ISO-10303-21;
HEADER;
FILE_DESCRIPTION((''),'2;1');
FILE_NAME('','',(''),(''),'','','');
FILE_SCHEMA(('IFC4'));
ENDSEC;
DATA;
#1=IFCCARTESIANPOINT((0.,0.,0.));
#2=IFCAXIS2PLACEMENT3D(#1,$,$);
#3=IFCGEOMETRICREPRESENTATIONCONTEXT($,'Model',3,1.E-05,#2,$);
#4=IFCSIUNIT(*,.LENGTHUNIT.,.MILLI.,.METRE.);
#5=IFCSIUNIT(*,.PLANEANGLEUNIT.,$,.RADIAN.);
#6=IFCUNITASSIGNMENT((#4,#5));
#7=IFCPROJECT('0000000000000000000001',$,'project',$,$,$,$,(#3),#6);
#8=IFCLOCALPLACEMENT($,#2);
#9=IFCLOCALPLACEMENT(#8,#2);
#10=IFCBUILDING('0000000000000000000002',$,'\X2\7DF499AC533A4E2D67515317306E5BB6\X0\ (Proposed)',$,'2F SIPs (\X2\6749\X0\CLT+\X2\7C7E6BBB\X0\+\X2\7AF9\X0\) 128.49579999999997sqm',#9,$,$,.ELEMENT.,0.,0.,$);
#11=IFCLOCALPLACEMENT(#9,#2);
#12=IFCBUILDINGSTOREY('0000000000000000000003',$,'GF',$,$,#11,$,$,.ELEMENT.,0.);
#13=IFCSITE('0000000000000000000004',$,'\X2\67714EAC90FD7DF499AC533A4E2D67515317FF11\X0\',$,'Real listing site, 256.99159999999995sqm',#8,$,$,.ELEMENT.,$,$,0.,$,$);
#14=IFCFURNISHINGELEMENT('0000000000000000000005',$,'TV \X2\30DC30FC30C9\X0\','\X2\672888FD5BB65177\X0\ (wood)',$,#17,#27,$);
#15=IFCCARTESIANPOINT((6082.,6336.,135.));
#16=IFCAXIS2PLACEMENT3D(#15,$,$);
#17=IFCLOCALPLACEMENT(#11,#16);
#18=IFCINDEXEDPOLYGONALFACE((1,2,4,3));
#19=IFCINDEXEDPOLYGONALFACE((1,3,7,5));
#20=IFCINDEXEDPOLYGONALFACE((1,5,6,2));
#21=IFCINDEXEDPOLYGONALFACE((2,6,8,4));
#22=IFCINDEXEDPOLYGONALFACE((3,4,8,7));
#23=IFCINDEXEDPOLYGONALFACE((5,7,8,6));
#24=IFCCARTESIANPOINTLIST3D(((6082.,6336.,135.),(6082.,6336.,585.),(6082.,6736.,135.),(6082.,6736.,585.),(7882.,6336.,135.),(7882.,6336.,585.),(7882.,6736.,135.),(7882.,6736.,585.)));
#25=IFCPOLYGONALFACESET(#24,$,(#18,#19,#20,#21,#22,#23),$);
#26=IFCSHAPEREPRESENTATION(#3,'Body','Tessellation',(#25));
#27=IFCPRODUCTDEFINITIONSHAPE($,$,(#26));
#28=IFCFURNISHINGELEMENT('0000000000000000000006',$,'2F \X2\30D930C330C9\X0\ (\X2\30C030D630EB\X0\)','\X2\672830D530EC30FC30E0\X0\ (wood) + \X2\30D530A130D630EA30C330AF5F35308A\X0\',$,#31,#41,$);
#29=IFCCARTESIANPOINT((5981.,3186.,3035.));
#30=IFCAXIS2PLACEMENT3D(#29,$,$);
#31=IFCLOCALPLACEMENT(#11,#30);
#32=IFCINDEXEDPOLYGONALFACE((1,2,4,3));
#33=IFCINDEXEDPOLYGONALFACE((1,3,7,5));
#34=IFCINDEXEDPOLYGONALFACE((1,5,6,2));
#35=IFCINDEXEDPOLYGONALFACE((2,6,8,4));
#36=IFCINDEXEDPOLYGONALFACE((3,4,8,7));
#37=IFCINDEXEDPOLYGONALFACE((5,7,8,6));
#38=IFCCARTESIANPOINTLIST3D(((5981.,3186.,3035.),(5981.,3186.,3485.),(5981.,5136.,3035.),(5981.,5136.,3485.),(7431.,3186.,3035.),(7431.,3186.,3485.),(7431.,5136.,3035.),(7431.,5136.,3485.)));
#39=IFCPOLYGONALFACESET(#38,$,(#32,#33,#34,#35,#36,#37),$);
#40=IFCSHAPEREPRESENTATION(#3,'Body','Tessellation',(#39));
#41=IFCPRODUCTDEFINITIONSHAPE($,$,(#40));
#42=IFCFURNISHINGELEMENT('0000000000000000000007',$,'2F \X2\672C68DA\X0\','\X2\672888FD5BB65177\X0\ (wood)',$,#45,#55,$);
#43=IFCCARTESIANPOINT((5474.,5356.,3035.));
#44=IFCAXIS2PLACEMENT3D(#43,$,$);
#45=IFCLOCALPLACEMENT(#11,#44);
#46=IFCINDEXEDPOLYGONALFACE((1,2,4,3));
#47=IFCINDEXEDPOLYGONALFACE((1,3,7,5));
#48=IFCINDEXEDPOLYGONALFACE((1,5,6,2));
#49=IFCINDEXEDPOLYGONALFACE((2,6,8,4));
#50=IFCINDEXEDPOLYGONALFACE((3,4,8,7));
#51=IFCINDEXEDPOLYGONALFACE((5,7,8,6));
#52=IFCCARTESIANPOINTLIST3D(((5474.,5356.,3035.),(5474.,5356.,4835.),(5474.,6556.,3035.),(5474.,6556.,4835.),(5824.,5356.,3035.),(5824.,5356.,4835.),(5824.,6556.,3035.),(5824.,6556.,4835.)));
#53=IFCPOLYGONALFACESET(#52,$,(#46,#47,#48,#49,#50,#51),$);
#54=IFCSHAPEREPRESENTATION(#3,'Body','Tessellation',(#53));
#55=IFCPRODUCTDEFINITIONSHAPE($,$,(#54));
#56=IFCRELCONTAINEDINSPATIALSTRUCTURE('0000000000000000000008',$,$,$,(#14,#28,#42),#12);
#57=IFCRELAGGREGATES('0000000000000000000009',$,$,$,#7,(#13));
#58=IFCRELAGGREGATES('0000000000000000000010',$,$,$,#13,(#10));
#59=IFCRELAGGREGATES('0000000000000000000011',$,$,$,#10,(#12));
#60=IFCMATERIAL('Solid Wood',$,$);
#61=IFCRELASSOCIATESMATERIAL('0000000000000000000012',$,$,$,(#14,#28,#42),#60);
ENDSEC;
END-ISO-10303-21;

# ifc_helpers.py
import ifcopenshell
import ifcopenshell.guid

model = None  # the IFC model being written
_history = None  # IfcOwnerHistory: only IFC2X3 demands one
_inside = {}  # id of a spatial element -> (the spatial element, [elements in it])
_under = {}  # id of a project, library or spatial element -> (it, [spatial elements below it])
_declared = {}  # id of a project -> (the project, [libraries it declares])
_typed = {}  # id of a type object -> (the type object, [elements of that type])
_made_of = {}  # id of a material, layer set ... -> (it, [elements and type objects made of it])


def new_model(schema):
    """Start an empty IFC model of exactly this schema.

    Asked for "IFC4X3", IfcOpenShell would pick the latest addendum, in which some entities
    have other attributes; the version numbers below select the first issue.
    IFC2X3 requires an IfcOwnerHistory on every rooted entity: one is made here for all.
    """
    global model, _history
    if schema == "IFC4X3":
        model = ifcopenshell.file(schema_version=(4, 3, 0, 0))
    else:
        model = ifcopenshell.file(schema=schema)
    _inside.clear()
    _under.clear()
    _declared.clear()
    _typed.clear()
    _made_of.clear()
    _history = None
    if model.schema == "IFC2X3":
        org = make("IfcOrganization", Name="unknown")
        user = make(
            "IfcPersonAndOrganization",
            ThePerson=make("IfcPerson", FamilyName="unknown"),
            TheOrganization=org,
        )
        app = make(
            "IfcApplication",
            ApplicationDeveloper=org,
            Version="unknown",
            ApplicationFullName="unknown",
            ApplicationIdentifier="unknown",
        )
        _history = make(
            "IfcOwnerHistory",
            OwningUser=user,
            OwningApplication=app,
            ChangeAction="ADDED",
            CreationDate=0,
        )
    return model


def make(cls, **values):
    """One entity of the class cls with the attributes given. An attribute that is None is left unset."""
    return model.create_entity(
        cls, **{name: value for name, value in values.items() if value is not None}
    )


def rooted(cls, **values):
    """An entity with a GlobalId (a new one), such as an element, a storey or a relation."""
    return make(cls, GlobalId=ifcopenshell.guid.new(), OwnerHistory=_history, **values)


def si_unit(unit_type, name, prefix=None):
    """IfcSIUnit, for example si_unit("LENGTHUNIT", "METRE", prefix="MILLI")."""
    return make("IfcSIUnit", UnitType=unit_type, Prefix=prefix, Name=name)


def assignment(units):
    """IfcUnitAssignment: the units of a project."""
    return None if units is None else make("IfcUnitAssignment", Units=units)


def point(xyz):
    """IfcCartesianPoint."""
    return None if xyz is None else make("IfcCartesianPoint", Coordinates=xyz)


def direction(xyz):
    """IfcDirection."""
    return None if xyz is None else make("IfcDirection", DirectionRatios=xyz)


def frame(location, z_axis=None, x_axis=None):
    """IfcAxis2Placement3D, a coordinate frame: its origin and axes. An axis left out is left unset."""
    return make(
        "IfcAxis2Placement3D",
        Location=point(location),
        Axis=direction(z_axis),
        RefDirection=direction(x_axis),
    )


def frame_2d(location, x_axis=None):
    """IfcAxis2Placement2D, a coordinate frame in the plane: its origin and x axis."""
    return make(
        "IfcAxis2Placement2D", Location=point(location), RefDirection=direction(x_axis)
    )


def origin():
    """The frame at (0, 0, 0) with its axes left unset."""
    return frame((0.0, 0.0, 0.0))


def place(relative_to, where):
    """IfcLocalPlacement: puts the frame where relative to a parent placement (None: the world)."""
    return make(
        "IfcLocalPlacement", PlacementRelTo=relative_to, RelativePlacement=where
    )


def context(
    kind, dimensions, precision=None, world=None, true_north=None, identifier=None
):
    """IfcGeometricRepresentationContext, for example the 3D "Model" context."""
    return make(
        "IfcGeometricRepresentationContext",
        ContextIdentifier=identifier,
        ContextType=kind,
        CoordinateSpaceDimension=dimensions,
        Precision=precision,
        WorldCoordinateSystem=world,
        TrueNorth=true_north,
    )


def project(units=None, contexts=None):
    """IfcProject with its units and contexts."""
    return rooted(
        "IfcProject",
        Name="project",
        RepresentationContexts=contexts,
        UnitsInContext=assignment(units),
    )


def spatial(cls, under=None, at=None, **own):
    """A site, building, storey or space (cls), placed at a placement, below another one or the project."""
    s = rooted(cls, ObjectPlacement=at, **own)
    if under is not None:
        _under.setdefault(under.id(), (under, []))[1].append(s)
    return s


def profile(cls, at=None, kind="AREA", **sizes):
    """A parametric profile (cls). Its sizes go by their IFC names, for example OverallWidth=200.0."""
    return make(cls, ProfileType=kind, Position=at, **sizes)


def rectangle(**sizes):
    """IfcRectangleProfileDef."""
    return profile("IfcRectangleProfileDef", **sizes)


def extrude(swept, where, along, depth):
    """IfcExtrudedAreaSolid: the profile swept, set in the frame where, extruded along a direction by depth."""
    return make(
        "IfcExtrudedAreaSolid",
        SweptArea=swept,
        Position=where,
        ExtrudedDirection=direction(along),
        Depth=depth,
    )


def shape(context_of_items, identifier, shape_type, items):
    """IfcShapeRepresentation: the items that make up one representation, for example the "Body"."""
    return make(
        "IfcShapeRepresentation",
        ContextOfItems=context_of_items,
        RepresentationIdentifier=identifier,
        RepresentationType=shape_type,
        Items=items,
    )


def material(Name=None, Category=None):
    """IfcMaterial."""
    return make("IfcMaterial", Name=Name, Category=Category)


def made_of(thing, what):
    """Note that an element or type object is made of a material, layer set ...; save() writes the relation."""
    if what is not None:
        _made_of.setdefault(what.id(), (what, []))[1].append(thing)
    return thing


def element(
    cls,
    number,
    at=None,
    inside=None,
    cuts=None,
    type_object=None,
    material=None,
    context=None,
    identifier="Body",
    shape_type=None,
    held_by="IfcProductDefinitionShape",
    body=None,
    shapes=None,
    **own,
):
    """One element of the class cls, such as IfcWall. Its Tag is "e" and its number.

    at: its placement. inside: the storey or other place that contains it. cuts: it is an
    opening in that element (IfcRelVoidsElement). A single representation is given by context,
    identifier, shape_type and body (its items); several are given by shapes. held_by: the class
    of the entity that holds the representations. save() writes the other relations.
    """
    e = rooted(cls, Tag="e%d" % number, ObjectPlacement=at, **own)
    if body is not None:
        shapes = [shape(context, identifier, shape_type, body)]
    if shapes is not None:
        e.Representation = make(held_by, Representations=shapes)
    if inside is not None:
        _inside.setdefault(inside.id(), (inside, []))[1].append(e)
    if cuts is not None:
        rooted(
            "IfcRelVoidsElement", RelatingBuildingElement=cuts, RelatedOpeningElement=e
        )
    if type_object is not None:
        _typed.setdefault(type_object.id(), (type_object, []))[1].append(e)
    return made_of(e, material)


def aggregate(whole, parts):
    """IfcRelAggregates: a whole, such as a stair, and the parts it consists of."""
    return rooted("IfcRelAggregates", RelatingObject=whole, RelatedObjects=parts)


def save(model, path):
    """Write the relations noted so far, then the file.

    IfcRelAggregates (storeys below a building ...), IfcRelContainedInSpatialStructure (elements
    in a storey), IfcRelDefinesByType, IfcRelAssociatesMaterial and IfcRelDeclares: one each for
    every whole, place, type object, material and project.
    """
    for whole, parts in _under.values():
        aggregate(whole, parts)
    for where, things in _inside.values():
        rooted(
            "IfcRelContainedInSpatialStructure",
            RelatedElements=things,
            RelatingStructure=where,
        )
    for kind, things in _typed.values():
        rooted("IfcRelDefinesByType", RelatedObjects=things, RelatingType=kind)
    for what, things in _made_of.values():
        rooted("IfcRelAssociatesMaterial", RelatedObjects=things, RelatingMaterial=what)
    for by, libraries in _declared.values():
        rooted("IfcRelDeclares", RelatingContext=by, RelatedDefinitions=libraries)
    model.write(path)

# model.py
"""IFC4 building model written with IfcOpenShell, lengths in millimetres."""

from ifc_helpers import new_model, si_unit, frame, frame_2d, origin, place, context, project, spatial, rectangle, extrude, material, element, save


model = new_model("IFC4")

# Units and contexts
model_context = context("Model", 3, precision=1e-05, world=origin())
ifc_project = project(units=[si_unit("LENGTHUNIT", "METRE", prefix="MILLI"), si_unit("PLANEANGLEUNIT", "RADIAN")], contexts=[model_context])

# Site, building, storey
site_placement = place(None, origin())
site = spatial("IfcSite", under=ifc_project, at=site_placement, Name="東京都練馬区中村北１", ObjectType="Real listing site, 256.99159999999995sqm", CompositionType="ELEMENT", RefElevation=0.0)
building_placement = place(site_placement, origin())
building = spatial("IfcBuilding", under=site, at=building_placement, Name="練馬区中村北の家 (Proposed)", ObjectType="2F SIPs (杉CLT+籾殻+竹) 128.49579999999997sqm", CompositionType="ELEMENT", ElevationOfRefHeight=0.0, ElevationOfTerrain=0.0)
storey_placement = place(building_placement, origin())
storey = spatial("IfcBuildingStorey", under=building, at=storey_placement, Name="GF", CompositionType="ELEMENT", Elevation=0.0)

# Shared definitions
ifc_material_1 = material(Name="Solid Wood")

# Furnishing elements
furnishing_1_placement = place(storey_placement, frame((6082.0, 6336.0, 135.0)))
element("IfcFurnishingElement", 1, at=furnishing_1_placement, inside=storey, material=ifc_material_1, Name="TV ボード", Description="木製家具 (wood)", context=model_context, shape_type="SweptSolid", body=[
    extrude(rectangle(XDim=1800.0, YDim=400.0, at=frame_2d((900.0, 200.0))), frame((6082.0, 6336.0, 135.0)), (0.0, 0.0, 1.0), 450.0),
])
furnishing_2_placement = place(storey_placement, frame((5981.0, 3186.0, 3035.0)))
element("IfcFurnishingElement", 2, at=furnishing_2_placement, inside=storey, material=ifc_material_1, Name="2F ベッド (ダブル)", Description="木フレーム (wood) + ファブリック張り", context=model_context, shape_type="SweptSolid", body=[
    extrude(rectangle(XDim=1450.0, YDim=1950.0, at=frame_2d((725.0, 975.0))), frame((5981.0, 3186.0, 3035.0)), (0.0, 0.0, 1.0), 450.0),
])
furnishing_3_placement = place(storey_placement, frame((5474.0, 5356.0, 3035.0)))
element("IfcFurnishingElement", 3, at=furnishing_3_placement, inside=storey, material=ifc_material_1, Name="2F 本棚", Description="木製家具 (wood)", context=model_context, shape_type="SweptSolid", body=[
    extrude(rectangle(XDim=350.0, YDim=1200.0, at=frame_2d((175.0, 600.0))), frame((5474.0, 5356.0, 3035.0)), (0.0, 0.0, 1.0), 1800.0),
])

save(model, "model.ifc")
